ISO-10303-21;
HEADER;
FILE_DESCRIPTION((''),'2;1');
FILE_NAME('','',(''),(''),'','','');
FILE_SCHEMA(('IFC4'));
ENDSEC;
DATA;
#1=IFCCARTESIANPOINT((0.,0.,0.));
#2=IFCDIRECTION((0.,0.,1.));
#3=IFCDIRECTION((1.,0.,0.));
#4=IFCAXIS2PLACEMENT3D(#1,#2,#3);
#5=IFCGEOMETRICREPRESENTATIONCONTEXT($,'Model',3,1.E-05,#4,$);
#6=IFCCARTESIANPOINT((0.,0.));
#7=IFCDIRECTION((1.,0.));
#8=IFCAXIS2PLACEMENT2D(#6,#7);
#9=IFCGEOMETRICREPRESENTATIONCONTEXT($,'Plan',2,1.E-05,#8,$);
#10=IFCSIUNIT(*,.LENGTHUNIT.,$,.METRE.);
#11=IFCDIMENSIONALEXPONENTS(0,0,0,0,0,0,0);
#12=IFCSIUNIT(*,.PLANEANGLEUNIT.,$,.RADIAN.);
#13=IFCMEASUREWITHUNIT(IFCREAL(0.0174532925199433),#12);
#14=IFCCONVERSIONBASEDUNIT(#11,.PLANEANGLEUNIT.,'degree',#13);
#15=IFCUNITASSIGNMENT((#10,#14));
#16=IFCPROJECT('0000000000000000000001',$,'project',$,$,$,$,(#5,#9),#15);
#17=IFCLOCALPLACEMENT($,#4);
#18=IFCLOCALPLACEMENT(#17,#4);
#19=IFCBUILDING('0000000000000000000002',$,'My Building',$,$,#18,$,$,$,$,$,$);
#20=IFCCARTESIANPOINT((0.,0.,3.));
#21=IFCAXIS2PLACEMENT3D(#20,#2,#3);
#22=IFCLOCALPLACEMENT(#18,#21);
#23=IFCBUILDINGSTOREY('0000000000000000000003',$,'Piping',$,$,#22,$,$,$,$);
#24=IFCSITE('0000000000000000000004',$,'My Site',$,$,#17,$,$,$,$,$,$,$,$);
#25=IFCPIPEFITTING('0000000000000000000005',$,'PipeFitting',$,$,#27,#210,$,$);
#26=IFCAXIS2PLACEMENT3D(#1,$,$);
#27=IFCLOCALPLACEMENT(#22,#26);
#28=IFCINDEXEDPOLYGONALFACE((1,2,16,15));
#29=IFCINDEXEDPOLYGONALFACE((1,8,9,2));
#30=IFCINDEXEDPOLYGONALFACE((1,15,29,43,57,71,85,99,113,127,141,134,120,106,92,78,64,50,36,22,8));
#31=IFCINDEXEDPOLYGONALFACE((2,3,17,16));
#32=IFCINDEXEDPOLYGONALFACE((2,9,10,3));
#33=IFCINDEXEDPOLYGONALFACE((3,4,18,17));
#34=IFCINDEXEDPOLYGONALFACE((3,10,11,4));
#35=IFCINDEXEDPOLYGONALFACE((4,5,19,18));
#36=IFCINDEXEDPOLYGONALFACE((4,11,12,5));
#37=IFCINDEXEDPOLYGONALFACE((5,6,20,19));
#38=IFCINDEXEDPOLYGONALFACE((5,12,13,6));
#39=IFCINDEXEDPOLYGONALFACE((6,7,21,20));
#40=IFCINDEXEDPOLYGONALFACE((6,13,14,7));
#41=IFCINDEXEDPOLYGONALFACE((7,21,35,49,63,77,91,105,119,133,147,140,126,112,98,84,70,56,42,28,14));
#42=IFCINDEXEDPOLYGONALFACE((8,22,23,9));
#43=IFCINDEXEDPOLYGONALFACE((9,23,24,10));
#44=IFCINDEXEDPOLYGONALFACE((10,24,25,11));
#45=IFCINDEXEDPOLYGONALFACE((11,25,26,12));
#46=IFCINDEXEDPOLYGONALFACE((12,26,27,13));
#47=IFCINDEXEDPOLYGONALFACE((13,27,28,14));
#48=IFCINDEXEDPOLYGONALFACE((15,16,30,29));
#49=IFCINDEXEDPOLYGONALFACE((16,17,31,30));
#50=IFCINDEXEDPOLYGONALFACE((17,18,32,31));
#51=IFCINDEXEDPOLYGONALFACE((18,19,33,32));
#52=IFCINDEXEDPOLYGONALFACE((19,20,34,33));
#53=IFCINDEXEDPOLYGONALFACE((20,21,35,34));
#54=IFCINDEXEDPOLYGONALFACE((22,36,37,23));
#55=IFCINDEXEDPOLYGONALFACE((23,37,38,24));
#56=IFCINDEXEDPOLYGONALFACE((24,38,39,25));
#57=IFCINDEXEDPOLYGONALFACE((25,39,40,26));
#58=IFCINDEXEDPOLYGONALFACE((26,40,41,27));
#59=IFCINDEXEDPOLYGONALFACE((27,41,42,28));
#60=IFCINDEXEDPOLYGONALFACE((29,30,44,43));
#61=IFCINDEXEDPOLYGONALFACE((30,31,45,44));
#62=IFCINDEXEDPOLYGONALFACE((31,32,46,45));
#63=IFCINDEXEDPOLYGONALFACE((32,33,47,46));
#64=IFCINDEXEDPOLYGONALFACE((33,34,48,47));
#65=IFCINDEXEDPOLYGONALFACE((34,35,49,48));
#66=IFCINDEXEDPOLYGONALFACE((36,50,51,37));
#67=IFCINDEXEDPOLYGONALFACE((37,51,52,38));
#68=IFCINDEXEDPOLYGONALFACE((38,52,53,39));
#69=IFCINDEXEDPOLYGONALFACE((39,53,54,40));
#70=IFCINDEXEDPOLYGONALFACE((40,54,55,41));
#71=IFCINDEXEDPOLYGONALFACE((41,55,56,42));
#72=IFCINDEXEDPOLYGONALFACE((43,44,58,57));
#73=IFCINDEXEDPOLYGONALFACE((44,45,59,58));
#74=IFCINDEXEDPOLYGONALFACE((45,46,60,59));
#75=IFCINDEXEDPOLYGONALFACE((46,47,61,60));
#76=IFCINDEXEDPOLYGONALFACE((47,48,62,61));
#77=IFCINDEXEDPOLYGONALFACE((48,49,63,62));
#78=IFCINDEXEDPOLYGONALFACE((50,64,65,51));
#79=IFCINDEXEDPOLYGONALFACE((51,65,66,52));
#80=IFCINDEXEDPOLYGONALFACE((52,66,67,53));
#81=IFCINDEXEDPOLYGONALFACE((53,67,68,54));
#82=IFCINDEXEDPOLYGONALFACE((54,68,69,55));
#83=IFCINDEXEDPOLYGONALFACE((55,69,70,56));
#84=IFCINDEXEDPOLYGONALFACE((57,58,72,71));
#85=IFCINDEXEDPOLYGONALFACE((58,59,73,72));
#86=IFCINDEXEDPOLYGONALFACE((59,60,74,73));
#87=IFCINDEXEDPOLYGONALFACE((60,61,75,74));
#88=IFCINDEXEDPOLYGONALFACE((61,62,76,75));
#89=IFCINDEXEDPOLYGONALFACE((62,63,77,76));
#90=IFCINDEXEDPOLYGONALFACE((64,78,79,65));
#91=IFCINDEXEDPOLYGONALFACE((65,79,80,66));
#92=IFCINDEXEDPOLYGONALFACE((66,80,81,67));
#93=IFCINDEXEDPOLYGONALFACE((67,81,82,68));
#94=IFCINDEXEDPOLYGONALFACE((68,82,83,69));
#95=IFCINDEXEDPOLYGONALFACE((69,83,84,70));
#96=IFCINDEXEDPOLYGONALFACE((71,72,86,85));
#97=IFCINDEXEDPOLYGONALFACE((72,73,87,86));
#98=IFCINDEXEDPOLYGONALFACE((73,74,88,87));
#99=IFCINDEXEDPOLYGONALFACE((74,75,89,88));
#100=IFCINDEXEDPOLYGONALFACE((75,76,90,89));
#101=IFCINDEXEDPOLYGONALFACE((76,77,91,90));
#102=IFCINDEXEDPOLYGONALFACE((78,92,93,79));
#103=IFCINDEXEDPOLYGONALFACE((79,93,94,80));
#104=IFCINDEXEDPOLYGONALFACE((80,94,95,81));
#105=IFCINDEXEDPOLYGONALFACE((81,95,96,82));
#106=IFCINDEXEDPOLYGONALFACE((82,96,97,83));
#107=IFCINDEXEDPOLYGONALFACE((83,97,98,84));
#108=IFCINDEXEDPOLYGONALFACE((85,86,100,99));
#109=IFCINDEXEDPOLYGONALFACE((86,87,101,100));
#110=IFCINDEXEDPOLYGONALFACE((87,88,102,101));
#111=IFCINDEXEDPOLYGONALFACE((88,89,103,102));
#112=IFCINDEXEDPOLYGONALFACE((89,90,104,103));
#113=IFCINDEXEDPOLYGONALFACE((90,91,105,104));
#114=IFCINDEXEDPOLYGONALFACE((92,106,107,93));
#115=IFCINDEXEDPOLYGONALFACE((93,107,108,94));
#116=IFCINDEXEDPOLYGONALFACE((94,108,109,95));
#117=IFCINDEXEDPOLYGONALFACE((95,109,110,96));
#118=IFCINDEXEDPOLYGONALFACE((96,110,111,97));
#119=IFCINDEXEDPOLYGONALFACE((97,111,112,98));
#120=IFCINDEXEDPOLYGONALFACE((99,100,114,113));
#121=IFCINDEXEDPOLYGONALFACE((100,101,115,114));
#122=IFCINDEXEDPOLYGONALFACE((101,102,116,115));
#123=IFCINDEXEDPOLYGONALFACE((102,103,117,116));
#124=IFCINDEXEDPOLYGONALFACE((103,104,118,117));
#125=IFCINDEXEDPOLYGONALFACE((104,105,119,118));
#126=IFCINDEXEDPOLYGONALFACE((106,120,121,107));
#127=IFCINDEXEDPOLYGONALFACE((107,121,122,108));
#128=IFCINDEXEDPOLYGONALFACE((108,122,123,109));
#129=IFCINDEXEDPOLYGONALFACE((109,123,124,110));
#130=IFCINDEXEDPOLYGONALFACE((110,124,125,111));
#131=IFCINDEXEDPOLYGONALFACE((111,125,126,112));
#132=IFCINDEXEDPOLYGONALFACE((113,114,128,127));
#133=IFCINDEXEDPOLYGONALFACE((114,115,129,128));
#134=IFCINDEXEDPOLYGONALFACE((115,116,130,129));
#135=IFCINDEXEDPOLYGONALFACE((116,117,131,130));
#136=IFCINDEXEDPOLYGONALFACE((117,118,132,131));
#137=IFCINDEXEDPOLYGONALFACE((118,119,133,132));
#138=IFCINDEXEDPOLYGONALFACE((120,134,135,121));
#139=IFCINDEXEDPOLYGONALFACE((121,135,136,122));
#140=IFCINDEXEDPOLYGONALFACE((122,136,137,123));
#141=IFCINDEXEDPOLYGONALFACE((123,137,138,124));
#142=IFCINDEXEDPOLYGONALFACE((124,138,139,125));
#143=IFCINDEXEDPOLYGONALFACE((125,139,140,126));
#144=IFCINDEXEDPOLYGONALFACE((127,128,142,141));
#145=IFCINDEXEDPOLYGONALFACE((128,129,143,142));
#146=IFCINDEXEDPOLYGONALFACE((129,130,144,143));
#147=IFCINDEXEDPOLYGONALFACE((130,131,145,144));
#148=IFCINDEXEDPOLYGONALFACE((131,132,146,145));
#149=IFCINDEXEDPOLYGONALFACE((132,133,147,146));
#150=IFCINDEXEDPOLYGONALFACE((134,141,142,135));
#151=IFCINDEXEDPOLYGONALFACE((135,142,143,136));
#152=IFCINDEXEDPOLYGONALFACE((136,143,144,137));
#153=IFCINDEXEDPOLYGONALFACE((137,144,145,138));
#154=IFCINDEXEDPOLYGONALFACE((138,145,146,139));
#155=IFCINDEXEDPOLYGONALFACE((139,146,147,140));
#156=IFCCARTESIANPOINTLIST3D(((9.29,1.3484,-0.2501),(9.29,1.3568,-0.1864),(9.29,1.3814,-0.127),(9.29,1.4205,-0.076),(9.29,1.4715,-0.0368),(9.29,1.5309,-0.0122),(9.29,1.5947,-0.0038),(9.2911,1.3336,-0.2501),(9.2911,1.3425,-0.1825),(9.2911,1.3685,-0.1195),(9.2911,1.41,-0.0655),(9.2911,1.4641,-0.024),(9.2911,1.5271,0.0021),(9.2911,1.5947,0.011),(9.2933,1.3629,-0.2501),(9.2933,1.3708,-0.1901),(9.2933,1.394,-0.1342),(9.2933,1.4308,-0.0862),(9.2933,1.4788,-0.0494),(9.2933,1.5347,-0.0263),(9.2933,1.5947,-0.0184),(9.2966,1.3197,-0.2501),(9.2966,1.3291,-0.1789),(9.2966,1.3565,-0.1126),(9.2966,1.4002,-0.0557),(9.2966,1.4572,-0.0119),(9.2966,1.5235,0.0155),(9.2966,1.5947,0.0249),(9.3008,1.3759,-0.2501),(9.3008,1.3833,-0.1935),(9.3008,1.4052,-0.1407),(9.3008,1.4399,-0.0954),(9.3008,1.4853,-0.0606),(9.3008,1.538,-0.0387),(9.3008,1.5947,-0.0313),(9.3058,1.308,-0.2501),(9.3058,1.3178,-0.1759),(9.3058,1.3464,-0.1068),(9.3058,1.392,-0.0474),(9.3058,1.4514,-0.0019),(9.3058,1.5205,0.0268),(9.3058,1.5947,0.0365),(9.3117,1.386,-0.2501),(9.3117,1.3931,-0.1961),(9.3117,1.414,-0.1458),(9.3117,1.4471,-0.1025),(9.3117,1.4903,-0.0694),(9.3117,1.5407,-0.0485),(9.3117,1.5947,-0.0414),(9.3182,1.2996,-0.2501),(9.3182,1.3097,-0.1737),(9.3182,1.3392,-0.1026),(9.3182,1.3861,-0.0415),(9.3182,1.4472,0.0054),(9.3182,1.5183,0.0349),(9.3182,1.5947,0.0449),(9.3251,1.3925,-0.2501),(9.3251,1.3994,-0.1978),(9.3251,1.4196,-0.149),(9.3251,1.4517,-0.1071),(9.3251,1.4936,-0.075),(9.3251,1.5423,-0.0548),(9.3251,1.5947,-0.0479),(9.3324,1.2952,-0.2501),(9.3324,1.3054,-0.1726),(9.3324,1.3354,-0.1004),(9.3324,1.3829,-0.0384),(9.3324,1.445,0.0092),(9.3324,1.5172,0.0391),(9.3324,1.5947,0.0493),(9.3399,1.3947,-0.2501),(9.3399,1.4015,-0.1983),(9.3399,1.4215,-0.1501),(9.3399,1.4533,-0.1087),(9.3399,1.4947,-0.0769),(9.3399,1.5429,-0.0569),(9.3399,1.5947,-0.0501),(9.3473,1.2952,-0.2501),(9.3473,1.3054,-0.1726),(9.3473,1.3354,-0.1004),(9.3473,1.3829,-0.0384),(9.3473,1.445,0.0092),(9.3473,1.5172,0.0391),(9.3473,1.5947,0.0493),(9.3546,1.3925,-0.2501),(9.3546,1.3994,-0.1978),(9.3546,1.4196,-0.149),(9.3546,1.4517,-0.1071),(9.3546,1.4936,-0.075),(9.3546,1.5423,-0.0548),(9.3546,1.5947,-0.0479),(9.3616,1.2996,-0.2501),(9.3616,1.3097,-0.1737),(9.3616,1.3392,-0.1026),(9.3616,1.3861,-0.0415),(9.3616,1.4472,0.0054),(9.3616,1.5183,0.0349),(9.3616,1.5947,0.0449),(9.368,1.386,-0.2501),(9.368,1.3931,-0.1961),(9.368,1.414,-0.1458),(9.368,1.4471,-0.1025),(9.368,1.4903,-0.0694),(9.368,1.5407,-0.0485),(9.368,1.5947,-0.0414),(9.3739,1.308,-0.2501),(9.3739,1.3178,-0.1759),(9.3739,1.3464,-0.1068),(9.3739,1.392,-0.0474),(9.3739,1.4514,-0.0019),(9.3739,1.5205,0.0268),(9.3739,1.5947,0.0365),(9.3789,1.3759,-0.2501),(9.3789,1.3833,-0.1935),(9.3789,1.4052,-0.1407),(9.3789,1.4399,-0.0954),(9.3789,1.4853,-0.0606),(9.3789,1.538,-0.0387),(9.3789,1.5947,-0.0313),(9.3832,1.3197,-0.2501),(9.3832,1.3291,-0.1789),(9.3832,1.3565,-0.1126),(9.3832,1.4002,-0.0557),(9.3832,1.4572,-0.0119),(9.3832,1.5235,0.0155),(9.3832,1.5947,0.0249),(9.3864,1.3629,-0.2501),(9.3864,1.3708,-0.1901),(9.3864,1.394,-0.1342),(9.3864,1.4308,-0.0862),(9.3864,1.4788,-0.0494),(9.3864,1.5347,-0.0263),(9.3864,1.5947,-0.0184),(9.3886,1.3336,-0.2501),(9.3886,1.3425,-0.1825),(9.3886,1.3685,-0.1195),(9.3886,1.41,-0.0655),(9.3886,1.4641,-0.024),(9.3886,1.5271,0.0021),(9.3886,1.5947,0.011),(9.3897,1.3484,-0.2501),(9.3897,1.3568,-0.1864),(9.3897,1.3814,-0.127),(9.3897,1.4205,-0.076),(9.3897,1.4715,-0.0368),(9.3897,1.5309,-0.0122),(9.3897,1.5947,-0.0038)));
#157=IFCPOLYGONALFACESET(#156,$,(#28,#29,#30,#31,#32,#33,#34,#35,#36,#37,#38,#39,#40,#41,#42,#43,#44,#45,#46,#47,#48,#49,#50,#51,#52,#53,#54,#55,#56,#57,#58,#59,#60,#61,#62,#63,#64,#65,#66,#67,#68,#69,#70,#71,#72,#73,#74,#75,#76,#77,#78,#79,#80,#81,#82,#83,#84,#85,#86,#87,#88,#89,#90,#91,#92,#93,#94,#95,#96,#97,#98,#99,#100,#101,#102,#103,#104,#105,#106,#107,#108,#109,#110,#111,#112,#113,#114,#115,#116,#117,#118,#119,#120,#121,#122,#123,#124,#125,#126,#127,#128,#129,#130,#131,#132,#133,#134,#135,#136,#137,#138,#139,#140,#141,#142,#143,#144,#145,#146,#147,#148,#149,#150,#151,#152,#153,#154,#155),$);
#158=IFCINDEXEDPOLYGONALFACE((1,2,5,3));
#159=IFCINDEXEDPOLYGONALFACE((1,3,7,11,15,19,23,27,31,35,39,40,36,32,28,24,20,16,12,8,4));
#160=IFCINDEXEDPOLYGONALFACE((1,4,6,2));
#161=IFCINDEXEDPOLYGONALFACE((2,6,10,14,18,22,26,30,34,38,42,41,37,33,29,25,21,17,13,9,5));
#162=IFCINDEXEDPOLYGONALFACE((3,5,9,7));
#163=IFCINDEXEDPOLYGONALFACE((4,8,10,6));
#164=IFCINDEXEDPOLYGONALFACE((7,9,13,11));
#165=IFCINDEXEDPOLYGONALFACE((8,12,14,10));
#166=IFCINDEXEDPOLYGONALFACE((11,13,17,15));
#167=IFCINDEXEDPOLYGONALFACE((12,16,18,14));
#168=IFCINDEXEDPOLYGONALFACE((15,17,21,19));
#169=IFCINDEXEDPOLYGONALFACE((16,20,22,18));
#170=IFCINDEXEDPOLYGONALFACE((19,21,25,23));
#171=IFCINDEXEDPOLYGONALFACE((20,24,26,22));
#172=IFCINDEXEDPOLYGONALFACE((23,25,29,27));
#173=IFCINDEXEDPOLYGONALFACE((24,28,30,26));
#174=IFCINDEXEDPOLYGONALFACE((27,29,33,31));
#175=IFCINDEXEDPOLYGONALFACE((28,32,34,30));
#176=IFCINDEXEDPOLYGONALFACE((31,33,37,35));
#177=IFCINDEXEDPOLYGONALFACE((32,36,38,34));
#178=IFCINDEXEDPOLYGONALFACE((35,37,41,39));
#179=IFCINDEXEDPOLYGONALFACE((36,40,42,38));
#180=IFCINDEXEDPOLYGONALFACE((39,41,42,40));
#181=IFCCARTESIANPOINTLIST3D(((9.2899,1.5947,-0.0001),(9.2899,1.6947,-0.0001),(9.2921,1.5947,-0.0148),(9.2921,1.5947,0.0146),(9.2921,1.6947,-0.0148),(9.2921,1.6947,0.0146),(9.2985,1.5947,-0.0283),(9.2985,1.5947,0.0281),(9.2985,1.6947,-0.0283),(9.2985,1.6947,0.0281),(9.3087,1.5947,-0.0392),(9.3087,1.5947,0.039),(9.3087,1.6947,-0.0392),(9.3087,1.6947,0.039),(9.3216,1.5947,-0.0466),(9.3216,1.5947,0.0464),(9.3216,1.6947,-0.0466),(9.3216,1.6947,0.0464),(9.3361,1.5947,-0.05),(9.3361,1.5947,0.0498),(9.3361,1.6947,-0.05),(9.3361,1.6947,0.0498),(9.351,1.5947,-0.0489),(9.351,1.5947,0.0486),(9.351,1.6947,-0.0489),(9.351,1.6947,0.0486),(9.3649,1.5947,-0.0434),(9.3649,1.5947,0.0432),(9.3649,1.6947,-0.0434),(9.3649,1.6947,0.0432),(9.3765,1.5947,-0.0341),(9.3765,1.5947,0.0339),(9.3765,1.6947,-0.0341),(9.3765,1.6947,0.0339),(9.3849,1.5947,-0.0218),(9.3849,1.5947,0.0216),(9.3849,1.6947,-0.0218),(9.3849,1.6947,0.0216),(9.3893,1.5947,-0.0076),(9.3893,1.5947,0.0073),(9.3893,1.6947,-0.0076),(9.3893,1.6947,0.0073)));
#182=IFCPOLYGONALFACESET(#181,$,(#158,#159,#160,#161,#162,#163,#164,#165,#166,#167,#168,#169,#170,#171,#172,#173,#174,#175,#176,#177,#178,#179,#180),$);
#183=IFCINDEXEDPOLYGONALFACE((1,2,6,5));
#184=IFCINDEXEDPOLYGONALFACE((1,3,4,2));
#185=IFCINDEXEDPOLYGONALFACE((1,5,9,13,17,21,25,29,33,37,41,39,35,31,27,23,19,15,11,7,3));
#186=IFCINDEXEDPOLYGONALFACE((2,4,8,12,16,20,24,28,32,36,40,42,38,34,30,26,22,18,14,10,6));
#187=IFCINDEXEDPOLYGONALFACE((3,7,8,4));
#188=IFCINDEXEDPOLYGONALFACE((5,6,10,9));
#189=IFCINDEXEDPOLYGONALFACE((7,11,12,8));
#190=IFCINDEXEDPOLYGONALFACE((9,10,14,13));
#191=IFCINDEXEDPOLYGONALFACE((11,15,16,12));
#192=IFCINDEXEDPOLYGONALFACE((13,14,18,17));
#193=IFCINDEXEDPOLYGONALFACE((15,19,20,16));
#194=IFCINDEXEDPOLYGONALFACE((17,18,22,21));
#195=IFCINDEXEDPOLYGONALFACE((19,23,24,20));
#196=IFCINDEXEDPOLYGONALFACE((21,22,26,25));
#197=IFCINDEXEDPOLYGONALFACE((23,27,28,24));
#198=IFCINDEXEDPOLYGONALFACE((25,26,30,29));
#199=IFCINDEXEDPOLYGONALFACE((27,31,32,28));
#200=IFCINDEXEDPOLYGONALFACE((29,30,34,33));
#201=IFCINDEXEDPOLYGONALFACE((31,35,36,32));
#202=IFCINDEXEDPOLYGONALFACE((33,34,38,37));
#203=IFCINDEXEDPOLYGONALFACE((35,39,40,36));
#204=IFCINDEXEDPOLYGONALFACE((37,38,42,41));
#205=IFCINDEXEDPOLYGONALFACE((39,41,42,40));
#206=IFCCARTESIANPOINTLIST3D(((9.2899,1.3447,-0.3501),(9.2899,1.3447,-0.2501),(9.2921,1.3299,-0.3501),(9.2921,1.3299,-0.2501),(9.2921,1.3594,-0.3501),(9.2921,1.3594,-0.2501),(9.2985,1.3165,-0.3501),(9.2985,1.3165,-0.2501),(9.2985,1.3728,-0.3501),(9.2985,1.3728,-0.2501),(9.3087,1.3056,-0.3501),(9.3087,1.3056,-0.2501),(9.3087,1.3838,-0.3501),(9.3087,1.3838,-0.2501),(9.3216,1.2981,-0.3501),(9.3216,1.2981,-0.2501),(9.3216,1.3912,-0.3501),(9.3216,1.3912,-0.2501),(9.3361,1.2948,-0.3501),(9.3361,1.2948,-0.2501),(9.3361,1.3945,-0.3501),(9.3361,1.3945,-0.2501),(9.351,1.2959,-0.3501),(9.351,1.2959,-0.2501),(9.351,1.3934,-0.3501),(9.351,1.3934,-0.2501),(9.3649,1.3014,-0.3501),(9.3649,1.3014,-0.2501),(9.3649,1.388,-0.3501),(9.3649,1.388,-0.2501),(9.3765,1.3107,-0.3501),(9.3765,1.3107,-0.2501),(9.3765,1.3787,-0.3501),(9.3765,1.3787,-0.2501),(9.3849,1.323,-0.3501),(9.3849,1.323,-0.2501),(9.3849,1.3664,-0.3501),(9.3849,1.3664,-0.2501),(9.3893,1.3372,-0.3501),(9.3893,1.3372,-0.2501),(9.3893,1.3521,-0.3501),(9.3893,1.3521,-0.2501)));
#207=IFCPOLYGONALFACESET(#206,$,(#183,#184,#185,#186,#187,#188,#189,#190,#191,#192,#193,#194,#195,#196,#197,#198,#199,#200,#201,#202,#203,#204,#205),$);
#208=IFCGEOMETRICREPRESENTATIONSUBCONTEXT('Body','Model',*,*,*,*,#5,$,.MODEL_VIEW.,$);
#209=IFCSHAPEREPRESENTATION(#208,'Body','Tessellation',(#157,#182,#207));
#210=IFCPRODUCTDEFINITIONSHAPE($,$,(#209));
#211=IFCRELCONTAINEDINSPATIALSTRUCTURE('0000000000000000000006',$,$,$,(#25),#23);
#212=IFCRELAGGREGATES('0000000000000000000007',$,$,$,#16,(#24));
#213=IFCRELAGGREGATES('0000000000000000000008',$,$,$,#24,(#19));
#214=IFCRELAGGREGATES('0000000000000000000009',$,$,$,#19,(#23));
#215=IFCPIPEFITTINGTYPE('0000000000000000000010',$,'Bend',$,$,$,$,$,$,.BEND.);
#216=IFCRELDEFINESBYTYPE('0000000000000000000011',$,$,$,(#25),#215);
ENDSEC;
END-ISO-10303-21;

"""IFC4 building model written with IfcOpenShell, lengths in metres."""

from ifc_helpers import new_model, entity, si_unit, converted_unit, frame, origin_with_axes, origin_2d_with_axis, place, context, subcontext, project, spatial, circle, extrude, source, transform, mapped, type_object, type_shapes, element, save


model = new_model("IFC4")

# Units and contexts
model_context = context("Model", 3, precision=1e-05, world=origin_with_axes())
plan_context = context("Plan", 2, precision=1e-05, world=origin_2d_with_axis())
body_context = subcontext(model_context, "Body", "Model", "MODEL_VIEW")
ifc_project = project(units=[si_unit("LENGTHUNIT", "METRE"), converted_unit("PLANEANGLEUNIT", "degree", entity("IfcReal", 0.0174532925199433), si_unit("PLANEANGLEUNIT", "RADIAN"), dimensions=[0, 0, 0, 0, 0, 0, 0])], contexts=[model_context, plan_context])

# Site, building, storey
site_placement = place(None, origin_with_axes())
site = spatial("IfcSite", under=ifc_project, at=site_placement, Name="My Site")
building_placement = place(site_placement, origin_with_axes())
building = spatial("IfcBuilding", under=site, at=building_placement, Name="My Building")
storey_placement = place(building_placement, frame((0.0, 0.0, 3.0), z_axis=(0.0, 0.0, 1.0), x_axis=(1.0, 0.0, 0.0)))
storey = spatial("IfcBuildingStorey", under=building, at=storey_placement, Name="Piping")

# Pipe fitting
pipe_fitting_type = type_object("IfcPipeFittingType", Name="Bend", PredefinedType="BEND")
shared_shape = source(origin_with_axes(), body_context, "Body", "SolidModel", [
    entity("IfcSweptDiskSolid", entity("IfcIndexedPolyCurve", entity("IfcCartesianPointList3D", [[0.0, 0.0, -0.1], [0.0, -0.0732, -0.2768], [0.0, -0.25, -0.35]]), [entity("IfcArcIndex", [1, 2, 3])]), 0.05),
    extrude(circle(Radius=0.05), origin_with_axes(), (0.0, 0.0, -1.0), 0.1),
    extrude(circle(Radius=0.05), frame((0.0, -0.25, -0.35), z_axis=(0.0, -1.0, 0.0), x_axis=(1.0, 0.0, 0.0)), (0.0, 0.0, 1.0), 0.1),
])
type_shapes(pipe_fitting_type, [shared_shape])
for number, where, z_axis, x_axis, name in (
    (1, (9.3399, 1.6947, -0.0001), (0.0, 1.0, 0.0), (-1.0, 0.0, 0.0), "PipeFitting"),
):
    element("IfcPipeFitting", number, at=place(storey_placement, frame(where, z_axis=z_axis, x_axis=x_axis)), inside=storey, type_object=pipe_fitting_type, Name=name, context=body_context, shape_type="MappedRepresentation", body=[
        mapped(shared_shape, transform((0.0, 0.0, 0.0), x_axis=(1.0, 0.0, 0.0), y_axis=(0.0, 1.0, 0.0), z_axis=(0.0, 0.0, 1.0), scale=1.0)),
    ])

save(model, "model.ifc")
